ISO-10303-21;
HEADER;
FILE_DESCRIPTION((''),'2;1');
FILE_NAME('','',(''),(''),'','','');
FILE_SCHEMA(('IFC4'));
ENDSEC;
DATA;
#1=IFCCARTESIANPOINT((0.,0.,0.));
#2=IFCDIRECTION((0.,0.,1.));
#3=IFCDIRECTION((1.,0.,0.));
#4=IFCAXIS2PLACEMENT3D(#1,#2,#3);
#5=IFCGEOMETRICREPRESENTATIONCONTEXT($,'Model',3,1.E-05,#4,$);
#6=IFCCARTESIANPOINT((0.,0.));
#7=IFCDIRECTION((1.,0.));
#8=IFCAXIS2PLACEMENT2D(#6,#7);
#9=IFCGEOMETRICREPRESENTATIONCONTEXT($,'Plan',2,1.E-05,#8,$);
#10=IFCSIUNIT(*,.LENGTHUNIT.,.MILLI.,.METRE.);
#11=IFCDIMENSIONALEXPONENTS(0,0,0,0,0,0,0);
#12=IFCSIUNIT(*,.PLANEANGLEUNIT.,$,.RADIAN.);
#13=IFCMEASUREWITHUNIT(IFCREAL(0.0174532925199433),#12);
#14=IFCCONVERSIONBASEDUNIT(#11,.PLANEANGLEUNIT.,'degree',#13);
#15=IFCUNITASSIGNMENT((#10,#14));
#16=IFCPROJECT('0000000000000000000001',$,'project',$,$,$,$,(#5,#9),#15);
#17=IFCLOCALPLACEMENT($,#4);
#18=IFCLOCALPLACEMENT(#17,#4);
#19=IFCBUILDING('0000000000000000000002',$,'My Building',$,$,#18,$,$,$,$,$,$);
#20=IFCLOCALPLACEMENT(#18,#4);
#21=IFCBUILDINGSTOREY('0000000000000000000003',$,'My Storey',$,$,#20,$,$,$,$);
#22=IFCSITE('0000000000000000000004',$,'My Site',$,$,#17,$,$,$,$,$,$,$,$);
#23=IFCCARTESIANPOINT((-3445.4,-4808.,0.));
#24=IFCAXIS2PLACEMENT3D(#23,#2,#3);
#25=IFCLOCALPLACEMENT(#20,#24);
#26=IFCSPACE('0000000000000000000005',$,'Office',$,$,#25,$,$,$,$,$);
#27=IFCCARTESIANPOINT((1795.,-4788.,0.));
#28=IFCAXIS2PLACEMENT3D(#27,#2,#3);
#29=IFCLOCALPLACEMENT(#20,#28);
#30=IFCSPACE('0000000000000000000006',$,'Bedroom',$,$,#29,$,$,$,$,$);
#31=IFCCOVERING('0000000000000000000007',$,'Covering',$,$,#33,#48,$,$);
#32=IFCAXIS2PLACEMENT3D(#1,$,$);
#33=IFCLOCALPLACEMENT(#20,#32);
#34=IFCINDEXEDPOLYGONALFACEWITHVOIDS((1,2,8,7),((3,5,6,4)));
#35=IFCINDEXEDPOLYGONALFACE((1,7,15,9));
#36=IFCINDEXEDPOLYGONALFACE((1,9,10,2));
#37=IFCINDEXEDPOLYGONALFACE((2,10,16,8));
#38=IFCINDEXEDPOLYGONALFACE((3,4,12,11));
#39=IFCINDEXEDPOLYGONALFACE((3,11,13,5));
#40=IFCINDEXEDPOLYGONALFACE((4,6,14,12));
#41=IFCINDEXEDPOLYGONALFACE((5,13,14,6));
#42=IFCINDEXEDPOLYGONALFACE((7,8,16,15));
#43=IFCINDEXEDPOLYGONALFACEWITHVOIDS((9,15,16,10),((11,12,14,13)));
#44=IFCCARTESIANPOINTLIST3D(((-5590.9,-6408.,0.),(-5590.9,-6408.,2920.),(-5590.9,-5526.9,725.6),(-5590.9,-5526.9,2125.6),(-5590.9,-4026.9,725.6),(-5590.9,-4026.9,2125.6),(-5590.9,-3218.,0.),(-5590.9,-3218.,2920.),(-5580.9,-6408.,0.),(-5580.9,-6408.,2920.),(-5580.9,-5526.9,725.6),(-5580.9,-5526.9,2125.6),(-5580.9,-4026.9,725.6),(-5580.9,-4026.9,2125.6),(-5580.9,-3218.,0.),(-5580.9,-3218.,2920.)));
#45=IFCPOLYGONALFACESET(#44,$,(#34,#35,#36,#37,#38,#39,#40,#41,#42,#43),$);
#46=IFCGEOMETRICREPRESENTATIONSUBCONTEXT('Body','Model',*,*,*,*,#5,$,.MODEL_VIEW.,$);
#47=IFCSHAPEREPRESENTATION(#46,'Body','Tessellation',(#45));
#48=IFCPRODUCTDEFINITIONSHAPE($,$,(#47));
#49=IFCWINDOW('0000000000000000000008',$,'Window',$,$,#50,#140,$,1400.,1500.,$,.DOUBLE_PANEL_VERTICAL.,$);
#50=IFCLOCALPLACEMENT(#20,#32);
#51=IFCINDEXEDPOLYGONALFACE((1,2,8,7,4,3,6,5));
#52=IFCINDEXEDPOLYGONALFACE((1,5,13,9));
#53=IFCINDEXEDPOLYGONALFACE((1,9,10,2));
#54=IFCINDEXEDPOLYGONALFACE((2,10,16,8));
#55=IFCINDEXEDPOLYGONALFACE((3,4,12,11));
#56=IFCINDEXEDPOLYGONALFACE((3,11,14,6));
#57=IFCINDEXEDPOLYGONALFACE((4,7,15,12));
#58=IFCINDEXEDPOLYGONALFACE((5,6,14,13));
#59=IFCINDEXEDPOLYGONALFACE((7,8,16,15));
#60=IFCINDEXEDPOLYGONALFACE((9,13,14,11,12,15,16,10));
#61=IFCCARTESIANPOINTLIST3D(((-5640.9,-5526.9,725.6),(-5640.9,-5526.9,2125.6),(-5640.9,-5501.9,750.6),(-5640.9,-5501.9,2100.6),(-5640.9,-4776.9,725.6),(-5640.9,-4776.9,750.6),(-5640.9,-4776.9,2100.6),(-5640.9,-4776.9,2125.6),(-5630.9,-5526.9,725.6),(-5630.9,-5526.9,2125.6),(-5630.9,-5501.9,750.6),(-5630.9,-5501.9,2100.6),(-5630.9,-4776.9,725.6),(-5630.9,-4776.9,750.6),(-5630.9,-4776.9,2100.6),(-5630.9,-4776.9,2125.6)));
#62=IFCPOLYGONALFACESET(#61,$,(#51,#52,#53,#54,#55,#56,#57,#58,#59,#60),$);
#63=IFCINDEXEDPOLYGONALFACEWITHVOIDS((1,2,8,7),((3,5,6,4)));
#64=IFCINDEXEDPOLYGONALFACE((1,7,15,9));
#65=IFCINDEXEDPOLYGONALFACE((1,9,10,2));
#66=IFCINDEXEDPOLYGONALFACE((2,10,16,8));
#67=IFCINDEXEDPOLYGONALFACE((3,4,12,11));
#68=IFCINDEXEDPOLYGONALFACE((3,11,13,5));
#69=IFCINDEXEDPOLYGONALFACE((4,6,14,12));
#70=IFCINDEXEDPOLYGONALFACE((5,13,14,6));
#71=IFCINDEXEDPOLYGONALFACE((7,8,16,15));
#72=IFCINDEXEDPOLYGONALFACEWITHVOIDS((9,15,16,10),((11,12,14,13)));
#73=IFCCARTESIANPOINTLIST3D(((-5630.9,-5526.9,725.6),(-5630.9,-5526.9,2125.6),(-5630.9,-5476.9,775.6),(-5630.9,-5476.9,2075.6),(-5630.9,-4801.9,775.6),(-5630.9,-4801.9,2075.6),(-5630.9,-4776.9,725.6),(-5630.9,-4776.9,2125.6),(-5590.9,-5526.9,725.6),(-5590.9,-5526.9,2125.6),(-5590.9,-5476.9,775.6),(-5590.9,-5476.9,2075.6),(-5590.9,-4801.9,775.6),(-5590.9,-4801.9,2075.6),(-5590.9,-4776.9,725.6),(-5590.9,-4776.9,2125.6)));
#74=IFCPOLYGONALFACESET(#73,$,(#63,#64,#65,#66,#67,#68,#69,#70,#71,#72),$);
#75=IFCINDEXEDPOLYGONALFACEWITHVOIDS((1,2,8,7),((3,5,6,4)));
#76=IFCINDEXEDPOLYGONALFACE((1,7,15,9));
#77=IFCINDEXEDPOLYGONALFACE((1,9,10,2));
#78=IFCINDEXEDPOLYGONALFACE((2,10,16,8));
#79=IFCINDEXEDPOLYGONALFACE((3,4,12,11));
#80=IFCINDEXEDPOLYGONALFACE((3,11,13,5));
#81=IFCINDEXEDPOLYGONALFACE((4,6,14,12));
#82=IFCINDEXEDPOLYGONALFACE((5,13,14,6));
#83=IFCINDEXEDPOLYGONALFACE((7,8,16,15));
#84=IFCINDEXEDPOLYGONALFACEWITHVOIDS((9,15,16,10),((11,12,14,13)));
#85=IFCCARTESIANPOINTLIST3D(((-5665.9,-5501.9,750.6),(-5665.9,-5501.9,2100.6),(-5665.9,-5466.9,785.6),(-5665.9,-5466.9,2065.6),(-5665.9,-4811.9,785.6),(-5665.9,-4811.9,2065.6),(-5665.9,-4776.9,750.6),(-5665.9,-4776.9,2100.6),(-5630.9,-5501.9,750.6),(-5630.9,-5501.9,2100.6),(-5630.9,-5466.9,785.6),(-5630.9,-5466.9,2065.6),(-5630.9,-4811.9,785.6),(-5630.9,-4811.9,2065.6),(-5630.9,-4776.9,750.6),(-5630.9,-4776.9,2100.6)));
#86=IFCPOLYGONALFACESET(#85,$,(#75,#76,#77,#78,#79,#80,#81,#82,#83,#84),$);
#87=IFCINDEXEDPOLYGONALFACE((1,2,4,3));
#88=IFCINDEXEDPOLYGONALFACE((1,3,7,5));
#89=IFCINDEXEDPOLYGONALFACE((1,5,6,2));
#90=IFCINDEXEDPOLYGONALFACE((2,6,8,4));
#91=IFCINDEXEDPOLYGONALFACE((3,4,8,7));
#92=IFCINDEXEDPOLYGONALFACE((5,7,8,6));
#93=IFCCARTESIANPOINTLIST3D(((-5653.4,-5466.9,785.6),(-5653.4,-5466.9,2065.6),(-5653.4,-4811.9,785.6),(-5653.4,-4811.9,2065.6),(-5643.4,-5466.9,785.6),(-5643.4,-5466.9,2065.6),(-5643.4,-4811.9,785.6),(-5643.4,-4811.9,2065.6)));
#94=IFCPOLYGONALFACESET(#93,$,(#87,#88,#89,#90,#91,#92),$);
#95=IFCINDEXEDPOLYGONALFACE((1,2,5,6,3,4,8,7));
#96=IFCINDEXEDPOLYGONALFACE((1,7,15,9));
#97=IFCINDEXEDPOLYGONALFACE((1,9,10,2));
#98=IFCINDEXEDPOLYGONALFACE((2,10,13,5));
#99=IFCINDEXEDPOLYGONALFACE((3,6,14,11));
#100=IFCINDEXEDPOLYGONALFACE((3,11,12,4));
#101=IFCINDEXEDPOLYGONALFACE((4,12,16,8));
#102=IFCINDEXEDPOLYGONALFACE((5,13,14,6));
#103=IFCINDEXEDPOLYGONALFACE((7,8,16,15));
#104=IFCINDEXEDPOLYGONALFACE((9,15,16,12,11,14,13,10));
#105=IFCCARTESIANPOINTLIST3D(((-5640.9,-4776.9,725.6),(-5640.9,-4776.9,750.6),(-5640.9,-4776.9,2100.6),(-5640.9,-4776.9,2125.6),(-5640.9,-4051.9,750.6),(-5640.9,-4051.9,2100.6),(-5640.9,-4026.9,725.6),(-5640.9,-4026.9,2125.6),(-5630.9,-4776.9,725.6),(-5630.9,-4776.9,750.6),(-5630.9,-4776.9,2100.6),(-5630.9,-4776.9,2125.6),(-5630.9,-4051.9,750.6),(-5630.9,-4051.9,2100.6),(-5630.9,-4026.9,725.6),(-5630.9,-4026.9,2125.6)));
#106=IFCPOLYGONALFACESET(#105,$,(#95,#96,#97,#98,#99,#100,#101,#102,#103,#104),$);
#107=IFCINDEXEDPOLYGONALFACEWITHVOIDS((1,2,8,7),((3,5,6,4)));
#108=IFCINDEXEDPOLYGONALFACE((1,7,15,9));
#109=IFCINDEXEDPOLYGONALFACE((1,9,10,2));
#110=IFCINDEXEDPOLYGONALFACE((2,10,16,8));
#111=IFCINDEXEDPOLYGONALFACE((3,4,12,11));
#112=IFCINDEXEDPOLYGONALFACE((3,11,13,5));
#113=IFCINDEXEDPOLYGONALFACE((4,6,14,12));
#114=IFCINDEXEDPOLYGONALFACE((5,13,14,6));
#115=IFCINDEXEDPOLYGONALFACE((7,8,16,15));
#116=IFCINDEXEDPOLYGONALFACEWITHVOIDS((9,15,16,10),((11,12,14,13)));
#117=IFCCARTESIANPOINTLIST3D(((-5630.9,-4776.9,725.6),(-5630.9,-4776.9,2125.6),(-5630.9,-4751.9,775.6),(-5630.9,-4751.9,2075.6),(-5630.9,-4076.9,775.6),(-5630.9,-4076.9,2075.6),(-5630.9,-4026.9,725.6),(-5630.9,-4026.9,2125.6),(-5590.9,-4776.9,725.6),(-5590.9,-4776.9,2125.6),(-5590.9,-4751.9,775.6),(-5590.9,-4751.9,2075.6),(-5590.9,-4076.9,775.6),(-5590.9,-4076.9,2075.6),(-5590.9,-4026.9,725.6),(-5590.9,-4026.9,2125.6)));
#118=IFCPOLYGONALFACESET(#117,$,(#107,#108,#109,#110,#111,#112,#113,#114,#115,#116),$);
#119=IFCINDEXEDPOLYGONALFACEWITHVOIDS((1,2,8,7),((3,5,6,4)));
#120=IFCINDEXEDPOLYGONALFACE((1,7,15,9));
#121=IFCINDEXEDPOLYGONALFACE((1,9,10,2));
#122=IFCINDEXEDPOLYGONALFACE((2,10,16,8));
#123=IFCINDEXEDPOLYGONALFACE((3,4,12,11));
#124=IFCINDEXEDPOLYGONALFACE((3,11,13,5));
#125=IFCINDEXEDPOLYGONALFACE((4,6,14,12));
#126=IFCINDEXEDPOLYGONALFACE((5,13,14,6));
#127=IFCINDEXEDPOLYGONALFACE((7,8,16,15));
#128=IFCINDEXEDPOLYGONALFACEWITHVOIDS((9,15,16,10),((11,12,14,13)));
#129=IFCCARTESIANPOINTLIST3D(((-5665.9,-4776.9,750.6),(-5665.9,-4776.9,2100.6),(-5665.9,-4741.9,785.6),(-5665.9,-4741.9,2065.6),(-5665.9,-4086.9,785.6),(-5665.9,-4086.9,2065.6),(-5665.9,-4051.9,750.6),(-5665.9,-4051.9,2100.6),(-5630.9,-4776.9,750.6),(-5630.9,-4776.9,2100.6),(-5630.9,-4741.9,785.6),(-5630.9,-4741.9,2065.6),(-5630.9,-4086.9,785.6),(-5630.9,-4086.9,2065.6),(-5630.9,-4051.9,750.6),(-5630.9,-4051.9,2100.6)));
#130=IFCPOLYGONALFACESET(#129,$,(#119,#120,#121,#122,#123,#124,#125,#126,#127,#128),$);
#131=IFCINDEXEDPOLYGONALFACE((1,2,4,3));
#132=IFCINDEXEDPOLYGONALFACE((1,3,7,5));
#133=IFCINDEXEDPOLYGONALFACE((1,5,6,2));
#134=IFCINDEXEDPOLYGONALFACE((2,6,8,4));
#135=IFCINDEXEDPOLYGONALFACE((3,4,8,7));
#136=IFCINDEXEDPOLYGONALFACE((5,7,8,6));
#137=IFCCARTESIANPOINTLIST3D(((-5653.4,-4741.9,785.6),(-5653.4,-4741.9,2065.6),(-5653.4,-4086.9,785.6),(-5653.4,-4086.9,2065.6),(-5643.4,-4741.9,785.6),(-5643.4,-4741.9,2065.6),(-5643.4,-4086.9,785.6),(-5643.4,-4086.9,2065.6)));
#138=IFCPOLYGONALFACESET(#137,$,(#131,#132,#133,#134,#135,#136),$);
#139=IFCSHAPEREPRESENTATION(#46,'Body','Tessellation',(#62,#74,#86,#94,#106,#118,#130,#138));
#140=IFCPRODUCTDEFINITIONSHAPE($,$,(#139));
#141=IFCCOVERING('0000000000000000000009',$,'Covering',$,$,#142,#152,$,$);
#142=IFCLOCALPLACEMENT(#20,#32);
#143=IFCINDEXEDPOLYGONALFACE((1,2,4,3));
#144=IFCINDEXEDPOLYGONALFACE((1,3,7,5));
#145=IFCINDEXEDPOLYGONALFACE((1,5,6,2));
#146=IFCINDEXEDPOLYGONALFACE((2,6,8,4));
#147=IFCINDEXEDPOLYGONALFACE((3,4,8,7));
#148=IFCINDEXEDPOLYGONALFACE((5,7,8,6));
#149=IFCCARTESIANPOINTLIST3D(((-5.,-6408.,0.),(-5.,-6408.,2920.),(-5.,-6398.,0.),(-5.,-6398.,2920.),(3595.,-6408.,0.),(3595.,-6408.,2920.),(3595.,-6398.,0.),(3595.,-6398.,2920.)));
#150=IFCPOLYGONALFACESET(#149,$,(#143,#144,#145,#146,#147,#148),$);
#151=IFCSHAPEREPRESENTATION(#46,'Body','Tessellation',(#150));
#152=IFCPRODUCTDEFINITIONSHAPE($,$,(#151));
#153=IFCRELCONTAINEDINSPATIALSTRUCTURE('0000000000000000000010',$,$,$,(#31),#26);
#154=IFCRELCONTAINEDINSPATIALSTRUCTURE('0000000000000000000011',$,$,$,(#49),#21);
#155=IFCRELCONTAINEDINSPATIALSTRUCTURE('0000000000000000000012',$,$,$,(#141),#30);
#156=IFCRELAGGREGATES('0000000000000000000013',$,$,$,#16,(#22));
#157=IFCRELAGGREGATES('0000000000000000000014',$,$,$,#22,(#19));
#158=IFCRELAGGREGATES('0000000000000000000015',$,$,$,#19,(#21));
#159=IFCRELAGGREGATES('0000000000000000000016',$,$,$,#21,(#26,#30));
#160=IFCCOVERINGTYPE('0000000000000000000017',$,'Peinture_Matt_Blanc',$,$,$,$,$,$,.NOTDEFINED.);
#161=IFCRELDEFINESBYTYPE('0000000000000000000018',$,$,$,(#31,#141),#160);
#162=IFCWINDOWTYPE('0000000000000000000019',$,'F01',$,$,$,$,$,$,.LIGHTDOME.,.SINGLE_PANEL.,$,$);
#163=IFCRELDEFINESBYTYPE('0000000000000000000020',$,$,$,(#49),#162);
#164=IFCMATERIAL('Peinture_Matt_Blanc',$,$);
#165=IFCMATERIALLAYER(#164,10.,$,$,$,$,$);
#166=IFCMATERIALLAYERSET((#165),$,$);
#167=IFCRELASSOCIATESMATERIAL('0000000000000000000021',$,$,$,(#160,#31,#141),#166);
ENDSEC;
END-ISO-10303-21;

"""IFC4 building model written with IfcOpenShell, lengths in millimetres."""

from ifc_helpers import new_model, entity, si_unit, converted_unit, frame, origin_with_axes, origin_2d_with_axis, place, context, subcontext, project, spatial, line, indexed_curve, outline, extrude, clip, halfspace, shape, source, transform, mapped, material, layer, layer_set, layer_usage, type_object, type_shapes, element, fill, save


model = new_model("IFC4")

# Units and contexts
model_context = context("Model", 3, precision=1e-05, world=origin_with_axes())
plan_context = context("Plan", 2, precision=1e-05, world=origin_2d_with_axis())
body_context_1 = subcontext(model_context, "Body", "Model", "MODEL_VIEW")
body_context_2 = subcontext(plan_context, "Body", "Plan", "PLAN_VIEW")
ifc_project = project(units=[si_unit("LENGTHUNIT", "METRE", prefix="MILLI"), converted_unit("PLANEANGLEUNIT", "degree", entity("IfcReal", 0.0174532925199433), si_unit("PLANEANGLEUNIT", "RADIAN"), dimensions=[0, 0, 0, 0, 0, 0, 0])], contexts=[model_context, plan_context])

# Site, building, storey
site_placement = place(None, origin_with_axes())
site = spatial("IfcSite", under=ifc_project, at=site_placement, Name="My Site")
building_placement = place(site_placement, origin_with_axes())
building = spatial("IfcBuilding", under=site, at=building_placement, Name="My Building")
storey_placement = place(building_placement, origin_with_axes())
storey = spatial("IfcBuildingStorey", under=building, at=storey_placement, Name="My Storey")

# Shared definitions
space_1_placement = place(storey_placement, frame((-3445.4, -4808.0, 0.0), z_axis=(0.0, 0.0, 1.0), x_axis=(1.0, 0.0, 0.0)))
space_1 = spatial("IfcSpace", under=storey, at=space_1_placement, Name="Office")

# Shared definitions
ifc_material_1 = material(Name="Peinture_Matt_Blanc")
ifc_layer_1 = layer(ifc_material_1, 10.0)
ifc_layer_set_1 = layer_set([ifc_layer_1])
covering_type_1 = type_object("IfcCoveringType", Name="Peinture_Matt_Blanc", PredefinedType="NOTDEFINED", material=ifc_layer_set_1)

# Covering, opening, window
ifc_layer_usage_1 = layer_usage(ifc_layer_set_1, "AXIS2", "POSITIVE", 0.0)
covering_1_placement = place(space_1_placement, frame((-2135.4, -1600.0, 0.0), z_axis=(0.0, 0.0, 1.0), x_axis=(0.000002, 1.0, 0.0)))
covering_1 = element("IfcCovering", 1, at=covering_1_placement, inside=space_1, type_object=covering_type_1, material=ifc_layer_usage_1, Name="Covering", context=body_context_1, shape_type="Clipping", body=[
    clip(clip(extrude(outline(indexed_curve([(0.0, 0.0), (0.0, 10.0), (3190.0, 10.0), (3190.0, 0.0), (0.0, 0.0)], self_intersect=False)), origin_with_axes(), (0.0, 0.0, 1.0), 2920.0), halfspace(frame((0.0, 0.0, 2920.0), z_axis=(0.0, 0.0, 1.0), x_axis=(-1.0, 0.0, 0.0)), False)), halfspace(frame((0.0, 0.0, 2920.0), z_axis=(0.0, 0.0, 1.0), x_axis=(-1.0, 0.0, 0.0)), False)),
])
shared_shape_1 = source(origin_with_axes(), body_context_1, "Body", "SweptSolid", [
    extrude(outline(indexed_curve([(0.0, 0.0), (1500.0, 0.0), (1500.0, 1400.0), (0.0, 1400.0)], segments=[line(1, 2, 3, 4, 1)])), frame((0.0, -600.0, 0.0), z_axis=(0.0, -1.0, 0.0), x_axis=(1.0, 0.0, 0.0)), (0.0, 0.0, -1.0), 1200.0),
])
opening_1_placement = place(covering_1_placement, frame((881.1, -40.0, 725.6), z_axis=(0.0, 0.0, 1.0), x_axis=(1.0, 0.0, 0.0)))
opening_1 = element("IfcOpeningElement", 2, at=opening_1_placement, cuts=covering_1, PredefinedType="OPENING", context=body_context_1, shape_type="MappedRepresentation", body=[
    mapped(shared_shape_1, transform((0.0, 0.0, 0.0), x_axis=(1.0, 0.0, 0.0), y_axis=(0.0, 1.0, 0.0), z_axis=(0.0, 0.0, 1.0), scale=1.0)),
])
window_type = type_object("IfcWindowType", Name="F01", PartitioningType="SINGLE_PANEL", PredefinedType="LIGHTDOME")
shared_shape_2 = source(origin_with_axes(), body_context_1, "Body", "SolidModel", [
    extrude(outline(indexed_curve([(750.0, 0.0), (0.0, 0.0), (0.0, 1400.0), (750.0, 1400.0), (750.0, 1375.0), (25.0, 1375.0), (25.0, 25.0), (750.0, 25.0)], segments=[line(1, 2, 3, 4, 5, 6, 7, 8, 1)])), frame((0.0, 90.0, 0.0), z_axis=(0.0, -1.0, 0.0), x_axis=(1.0, 0.0, 0.0)), (0.0, 0.0, -1.0), 10.0),
    extrude(outline(indexed_curve([(0.0, 0.0), (750.0, 0.0), (750.0, 1400.0), (0.0, 1400.0)], segments=[line(1, 2, 3, 4, 1)]), holes=[indexed_curve([(50.0, 50.0), (725.0, 50.0), (725.0, 1350.0), (50.0, 1350.0)], segments=[line(1, 2, 3, 4, 1)])]), frame((0.0, 50.0, 0.0), z_axis=(0.0, -1.0, 0.0), x_axis=(1.0, 0.0, 0.0)), (0.0, 0.0, -1.0), 40.0),
    extrude(outline(indexed_curve([(0.0, 0.0), (725.0, 0.0), (725.0, 1350.0), (0.0, 1350.0)], segments=[line(1, 2, 3, 4, 1)]), holes=[indexed_curve([(35.0, 35.0), (690.0, 35.0), (690.0, 1315.0), (35.0, 1315.0)], segments=[line(1, 2, 3, 4, 1)])]), frame((25.0, 90.0, 25.0), z_axis=(0.0, -1.0, 0.0), x_axis=(1.0, 0.0, 0.0)), (0.0, 0.0, -1.0), 35.0),
    extrude(outline(indexed_curve([(35.0, 35.0), (690.0, 35.0), (690.0, 1315.0), (35.0, 1315.0), (35.0, 35.0)])), frame((25.0, 102.5, 25.0), z_axis=(0.0, -1.0, 0.0), x_axis=(1.0, 0.0, 0.0)), (0.0, 0.0, -1.0), 10.0),
    extrude(outline(indexed_curve([(0.0, 1400.0), (750.0, 1400.0), (750.0, 0.0), (0.0, 0.0), (0.0, 25.0), (725.0, 25.0), (725.0, 1375.0), (0.0, 1375.0)], segments=[line(1, 2, 3, 4, 5, 6, 7, 8, 1)])), frame((750.0, 90.0, 0.0), z_axis=(0.0, -1.0, 0.0), x_axis=(1.0, 0.0, 0.0)), (0.0, 0.0, -1.0), 10.0),
    extrude(outline(indexed_curve([(0.0, 0.0), (750.0, 0.0), (750.0, 1400.0), (0.0, 1400.0)], segments=[line(1, 2, 3, 4, 1)]), holes=[indexed_curve([(25.0, 50.0), (700.0, 50.0), (700.0, 1350.0), (25.0, 1350.0)], segments=[line(1, 2, 3, 4, 1)])]), frame((750.0, 50.0, 0.0), z_axis=(0.0, -1.0, 0.0), x_axis=(1.0, 0.0, 0.0)), (0.0, 0.0, -1.0), 40.0),
    extrude(outline(indexed_curve([(0.0, 0.0), (725.0, 0.0), (725.0, 1350.0), (0.0, 1350.0)], segments=[line(1, 2, 3, 4, 1)]), holes=[indexed_curve([(35.0, 35.0), (690.0, 35.0), (690.0, 1315.0), (35.0, 1315.0)], segments=[line(1, 2, 3, 4, 1)])]), frame((750.0, 90.0, 25.0), z_axis=(0.0, -1.0, 0.0), x_axis=(1.0, 0.0, 0.0)), (0.0, 0.0, -1.0), 35.0),
    extrude(outline(indexed_curve([(35.0, 1315.0), (690.0, 1315.0), (690.0, 35.0), (35.0, 35.0), (35.0, 1315.0)])), frame((750.0, 102.5, 25.0), z_axis=(0.0, -1.0, 0.0), x_axis=(1.0, 0.0, 0.0)), (0.0, 0.0, -1.0), 10.0),
])
shared_shape_3 = source(origin_with_axes(), body_context_2, "Body", "Curve2D", [
    entity("IfcIndexedPolyCurve", entity("IfcCartesianPointList2D", [[50.0, 50.0], [725.0, 50.0]])),
    entity("IfcIndexedPolyCurve", entity("IfcCartesianPointList2D", [[0.0, 100.0], [25.0, 100.0], [25.0, 90.0], [50.0, 90.0], [50.0, 50.0], [0.0, 50.0]]), [entity("IfcLineIndex", [1, 2, 3, 4, 5, 6, 1])]),
    entity("IfcIndexedPolyCurve", entity("IfcCartesianPointList2D", [[750.0, 100.0], [750.0, 100.0], [750.0, 90.0], [725.0, 90.0], [725.0, 50.0], [750.0, 50.0]])),
    entity("IfcIndexedPolyCurve", entity("IfcCartesianPointList2D", [[25.0, 90.0], [60.0, 90.0], [60.0, 125.0], [25.0, 125.0]]), [entity("IfcLineIndex", [1, 2, 3, 4, 1])]),
    entity("IfcIndexedPolyCurve", entity("IfcCartesianPointList2D", [[750.0, 90.0], [715.0, 90.0], [715.0, 125.0], [750.0, 125.0]]), [entity("IfcLineIndex", [1, 2, 3, 4, 1])]),
    entity("IfcIndexedPolyCurve", entity("IfcCartesianPointList2D", [[60.0, 90.0], [715.0, 90.0]])),
    entity("IfcIndexedPolyCurve", entity("IfcCartesianPointList2D", [[60.0, 125.0], [715.0, 125.0]])),
    entity("IfcIndexedPolyCurve", entity("IfcCartesianPointList2D", [[60.0, 107.5], [715.0, 107.5]])),
    entity("IfcIndexedPolyCurve", entity("IfcCartesianPointList2D", [[775.0, 50.0], [1450.0, 50.0]])),
    entity("IfcIndexedPolyCurve", entity("IfcCartesianPointList2D", [[750.0, 100.0], [750.0, 100.0], [750.0, 90.0], [775.0, 90.0], [775.0, 50.0], [750.0, 50.0]])),
    entity("IfcIndexedPolyCurve", entity("IfcCartesianPointList2D", [[1500.0, 100.0], [1475.0, 100.0], [1475.0, 90.0], [1450.0, 90.0], [1450.0, 50.0], [1500.0, 50.0]]), [entity("IfcLineIndex", [1, 2, 3, 4, 5, 6, 1])]),
    entity("IfcIndexedPolyCurve", entity("IfcCartesianPointList2D", [[750.0, 90.0], [785.0, 90.0], [785.0, 125.0], [750.0, 125.0]]), [entity("IfcLineIndex", [1, 2, 3, 4, 1])]),
    entity("IfcIndexedPolyCurve", entity("IfcCartesianPointList2D", [[1475.0, 90.0], [1440.0, 90.0], [1440.0, 125.0], [1475.0, 125.0]]), [entity("IfcLineIndex", [1, 2, 3, 4, 1])]),
    entity("IfcIndexedPolyCurve", entity("IfcCartesianPointList2D", [[785.0, 90.0], [1440.0, 90.0]])),
    entity("IfcIndexedPolyCurve", entity("IfcCartesianPointList2D", [[785.0, 125.0], [1440.0, 125.0]])),
    entity("IfcIndexedPolyCurve", entity("IfcCartesianPointList2D", [[785.0, 107.5], [1440.0, 107.5]])),
])
type_shapes(window_type, [shared_shape_2, shared_shape_3])
window_placement = place(opening_1_placement, frame((0.0, 0.0, 0.0), z_axis=(0.0, 0.0, 1.0), x_axis=(1.0, 0.0, 0.0)))
window = element("IfcWindow", 3, at=window_placement, inside=storey, type_object=window_type, Name="Window", OverallHeight=1400.0, OverallWidth=1500.0, PartitioningType="DOUBLE_PANEL_VERTICAL", shapes=[
    shape(body_context_1, "Body", "MappedRepresentation", [mapped(shared_shape_2, transform((0.0, 0.0, 0.0), x_axis=(1.0, 0.0, 0.0), y_axis=(0.0, 1.0, 0.0), z_axis=(0.0, 0.0, 1.0), scale=1.0))]),
    shape(body_context_2, "Body", "MappedRepresentation", [mapped(shared_shape_3, transform((0.0, 0.0, 0.0), x_axis=(1.0, 0.0, 0.0), y_axis=(0.0, 1.0, 0.0), z_axis=(0.0, 0.0, 1.0), scale=1.0))]),
])
fill(opening_1, window)

# Shared definitions
space_2_placement = place(storey_placement, frame((1795.0, -4788.0, 0.0), z_axis=(0.0, 0.0, 1.0), x_axis=(1.0, 0.0, 0.0)))
space_2 = spatial("IfcSpace", under=storey, at=space_2_placement, Name="Bedroom")

# Covering
ifc_layer_usage_2 = layer_usage(ifc_layer_set_1, "AXIS2", "POSITIVE", 0.0)
covering_2_placement = place(space_2_placement, frame((-1800.0, -1620.0, 0.0), z_axis=(0.0, 0.0, 1.0), x_axis=(1.0, -0.000002, 0.0)))
element("IfcCovering", 4, at=covering_2_placement, inside=space_2, type_object=covering_type_1, material=ifc_layer_usage_2, Name="Covering", context=body_context_1, shape_type="Clipping", body=[
    clip(clip(extrude(outline(indexed_curve([(0.0, 0.0), (0.0, 10.0), (3600.0, 10.0), (3600.0, 0.0), (0.0, 0.0)], self_intersect=False)), origin_with_axes(), (0.0, 0.0, 1.0), 2920.0), halfspace(frame((0.0, 0.0, 2920.0), z_axis=(0.0, 0.0, 1.0), x_axis=(-1.0, 0.0, 0.0)), False)), halfspace(frame((0.0, 0.0, 2920.0), z_axis=(0.0, 0.0, 1.0), x_axis=(-1.0, 0.0, 0.0)), False)),
])

save(model, "model.ifc")
